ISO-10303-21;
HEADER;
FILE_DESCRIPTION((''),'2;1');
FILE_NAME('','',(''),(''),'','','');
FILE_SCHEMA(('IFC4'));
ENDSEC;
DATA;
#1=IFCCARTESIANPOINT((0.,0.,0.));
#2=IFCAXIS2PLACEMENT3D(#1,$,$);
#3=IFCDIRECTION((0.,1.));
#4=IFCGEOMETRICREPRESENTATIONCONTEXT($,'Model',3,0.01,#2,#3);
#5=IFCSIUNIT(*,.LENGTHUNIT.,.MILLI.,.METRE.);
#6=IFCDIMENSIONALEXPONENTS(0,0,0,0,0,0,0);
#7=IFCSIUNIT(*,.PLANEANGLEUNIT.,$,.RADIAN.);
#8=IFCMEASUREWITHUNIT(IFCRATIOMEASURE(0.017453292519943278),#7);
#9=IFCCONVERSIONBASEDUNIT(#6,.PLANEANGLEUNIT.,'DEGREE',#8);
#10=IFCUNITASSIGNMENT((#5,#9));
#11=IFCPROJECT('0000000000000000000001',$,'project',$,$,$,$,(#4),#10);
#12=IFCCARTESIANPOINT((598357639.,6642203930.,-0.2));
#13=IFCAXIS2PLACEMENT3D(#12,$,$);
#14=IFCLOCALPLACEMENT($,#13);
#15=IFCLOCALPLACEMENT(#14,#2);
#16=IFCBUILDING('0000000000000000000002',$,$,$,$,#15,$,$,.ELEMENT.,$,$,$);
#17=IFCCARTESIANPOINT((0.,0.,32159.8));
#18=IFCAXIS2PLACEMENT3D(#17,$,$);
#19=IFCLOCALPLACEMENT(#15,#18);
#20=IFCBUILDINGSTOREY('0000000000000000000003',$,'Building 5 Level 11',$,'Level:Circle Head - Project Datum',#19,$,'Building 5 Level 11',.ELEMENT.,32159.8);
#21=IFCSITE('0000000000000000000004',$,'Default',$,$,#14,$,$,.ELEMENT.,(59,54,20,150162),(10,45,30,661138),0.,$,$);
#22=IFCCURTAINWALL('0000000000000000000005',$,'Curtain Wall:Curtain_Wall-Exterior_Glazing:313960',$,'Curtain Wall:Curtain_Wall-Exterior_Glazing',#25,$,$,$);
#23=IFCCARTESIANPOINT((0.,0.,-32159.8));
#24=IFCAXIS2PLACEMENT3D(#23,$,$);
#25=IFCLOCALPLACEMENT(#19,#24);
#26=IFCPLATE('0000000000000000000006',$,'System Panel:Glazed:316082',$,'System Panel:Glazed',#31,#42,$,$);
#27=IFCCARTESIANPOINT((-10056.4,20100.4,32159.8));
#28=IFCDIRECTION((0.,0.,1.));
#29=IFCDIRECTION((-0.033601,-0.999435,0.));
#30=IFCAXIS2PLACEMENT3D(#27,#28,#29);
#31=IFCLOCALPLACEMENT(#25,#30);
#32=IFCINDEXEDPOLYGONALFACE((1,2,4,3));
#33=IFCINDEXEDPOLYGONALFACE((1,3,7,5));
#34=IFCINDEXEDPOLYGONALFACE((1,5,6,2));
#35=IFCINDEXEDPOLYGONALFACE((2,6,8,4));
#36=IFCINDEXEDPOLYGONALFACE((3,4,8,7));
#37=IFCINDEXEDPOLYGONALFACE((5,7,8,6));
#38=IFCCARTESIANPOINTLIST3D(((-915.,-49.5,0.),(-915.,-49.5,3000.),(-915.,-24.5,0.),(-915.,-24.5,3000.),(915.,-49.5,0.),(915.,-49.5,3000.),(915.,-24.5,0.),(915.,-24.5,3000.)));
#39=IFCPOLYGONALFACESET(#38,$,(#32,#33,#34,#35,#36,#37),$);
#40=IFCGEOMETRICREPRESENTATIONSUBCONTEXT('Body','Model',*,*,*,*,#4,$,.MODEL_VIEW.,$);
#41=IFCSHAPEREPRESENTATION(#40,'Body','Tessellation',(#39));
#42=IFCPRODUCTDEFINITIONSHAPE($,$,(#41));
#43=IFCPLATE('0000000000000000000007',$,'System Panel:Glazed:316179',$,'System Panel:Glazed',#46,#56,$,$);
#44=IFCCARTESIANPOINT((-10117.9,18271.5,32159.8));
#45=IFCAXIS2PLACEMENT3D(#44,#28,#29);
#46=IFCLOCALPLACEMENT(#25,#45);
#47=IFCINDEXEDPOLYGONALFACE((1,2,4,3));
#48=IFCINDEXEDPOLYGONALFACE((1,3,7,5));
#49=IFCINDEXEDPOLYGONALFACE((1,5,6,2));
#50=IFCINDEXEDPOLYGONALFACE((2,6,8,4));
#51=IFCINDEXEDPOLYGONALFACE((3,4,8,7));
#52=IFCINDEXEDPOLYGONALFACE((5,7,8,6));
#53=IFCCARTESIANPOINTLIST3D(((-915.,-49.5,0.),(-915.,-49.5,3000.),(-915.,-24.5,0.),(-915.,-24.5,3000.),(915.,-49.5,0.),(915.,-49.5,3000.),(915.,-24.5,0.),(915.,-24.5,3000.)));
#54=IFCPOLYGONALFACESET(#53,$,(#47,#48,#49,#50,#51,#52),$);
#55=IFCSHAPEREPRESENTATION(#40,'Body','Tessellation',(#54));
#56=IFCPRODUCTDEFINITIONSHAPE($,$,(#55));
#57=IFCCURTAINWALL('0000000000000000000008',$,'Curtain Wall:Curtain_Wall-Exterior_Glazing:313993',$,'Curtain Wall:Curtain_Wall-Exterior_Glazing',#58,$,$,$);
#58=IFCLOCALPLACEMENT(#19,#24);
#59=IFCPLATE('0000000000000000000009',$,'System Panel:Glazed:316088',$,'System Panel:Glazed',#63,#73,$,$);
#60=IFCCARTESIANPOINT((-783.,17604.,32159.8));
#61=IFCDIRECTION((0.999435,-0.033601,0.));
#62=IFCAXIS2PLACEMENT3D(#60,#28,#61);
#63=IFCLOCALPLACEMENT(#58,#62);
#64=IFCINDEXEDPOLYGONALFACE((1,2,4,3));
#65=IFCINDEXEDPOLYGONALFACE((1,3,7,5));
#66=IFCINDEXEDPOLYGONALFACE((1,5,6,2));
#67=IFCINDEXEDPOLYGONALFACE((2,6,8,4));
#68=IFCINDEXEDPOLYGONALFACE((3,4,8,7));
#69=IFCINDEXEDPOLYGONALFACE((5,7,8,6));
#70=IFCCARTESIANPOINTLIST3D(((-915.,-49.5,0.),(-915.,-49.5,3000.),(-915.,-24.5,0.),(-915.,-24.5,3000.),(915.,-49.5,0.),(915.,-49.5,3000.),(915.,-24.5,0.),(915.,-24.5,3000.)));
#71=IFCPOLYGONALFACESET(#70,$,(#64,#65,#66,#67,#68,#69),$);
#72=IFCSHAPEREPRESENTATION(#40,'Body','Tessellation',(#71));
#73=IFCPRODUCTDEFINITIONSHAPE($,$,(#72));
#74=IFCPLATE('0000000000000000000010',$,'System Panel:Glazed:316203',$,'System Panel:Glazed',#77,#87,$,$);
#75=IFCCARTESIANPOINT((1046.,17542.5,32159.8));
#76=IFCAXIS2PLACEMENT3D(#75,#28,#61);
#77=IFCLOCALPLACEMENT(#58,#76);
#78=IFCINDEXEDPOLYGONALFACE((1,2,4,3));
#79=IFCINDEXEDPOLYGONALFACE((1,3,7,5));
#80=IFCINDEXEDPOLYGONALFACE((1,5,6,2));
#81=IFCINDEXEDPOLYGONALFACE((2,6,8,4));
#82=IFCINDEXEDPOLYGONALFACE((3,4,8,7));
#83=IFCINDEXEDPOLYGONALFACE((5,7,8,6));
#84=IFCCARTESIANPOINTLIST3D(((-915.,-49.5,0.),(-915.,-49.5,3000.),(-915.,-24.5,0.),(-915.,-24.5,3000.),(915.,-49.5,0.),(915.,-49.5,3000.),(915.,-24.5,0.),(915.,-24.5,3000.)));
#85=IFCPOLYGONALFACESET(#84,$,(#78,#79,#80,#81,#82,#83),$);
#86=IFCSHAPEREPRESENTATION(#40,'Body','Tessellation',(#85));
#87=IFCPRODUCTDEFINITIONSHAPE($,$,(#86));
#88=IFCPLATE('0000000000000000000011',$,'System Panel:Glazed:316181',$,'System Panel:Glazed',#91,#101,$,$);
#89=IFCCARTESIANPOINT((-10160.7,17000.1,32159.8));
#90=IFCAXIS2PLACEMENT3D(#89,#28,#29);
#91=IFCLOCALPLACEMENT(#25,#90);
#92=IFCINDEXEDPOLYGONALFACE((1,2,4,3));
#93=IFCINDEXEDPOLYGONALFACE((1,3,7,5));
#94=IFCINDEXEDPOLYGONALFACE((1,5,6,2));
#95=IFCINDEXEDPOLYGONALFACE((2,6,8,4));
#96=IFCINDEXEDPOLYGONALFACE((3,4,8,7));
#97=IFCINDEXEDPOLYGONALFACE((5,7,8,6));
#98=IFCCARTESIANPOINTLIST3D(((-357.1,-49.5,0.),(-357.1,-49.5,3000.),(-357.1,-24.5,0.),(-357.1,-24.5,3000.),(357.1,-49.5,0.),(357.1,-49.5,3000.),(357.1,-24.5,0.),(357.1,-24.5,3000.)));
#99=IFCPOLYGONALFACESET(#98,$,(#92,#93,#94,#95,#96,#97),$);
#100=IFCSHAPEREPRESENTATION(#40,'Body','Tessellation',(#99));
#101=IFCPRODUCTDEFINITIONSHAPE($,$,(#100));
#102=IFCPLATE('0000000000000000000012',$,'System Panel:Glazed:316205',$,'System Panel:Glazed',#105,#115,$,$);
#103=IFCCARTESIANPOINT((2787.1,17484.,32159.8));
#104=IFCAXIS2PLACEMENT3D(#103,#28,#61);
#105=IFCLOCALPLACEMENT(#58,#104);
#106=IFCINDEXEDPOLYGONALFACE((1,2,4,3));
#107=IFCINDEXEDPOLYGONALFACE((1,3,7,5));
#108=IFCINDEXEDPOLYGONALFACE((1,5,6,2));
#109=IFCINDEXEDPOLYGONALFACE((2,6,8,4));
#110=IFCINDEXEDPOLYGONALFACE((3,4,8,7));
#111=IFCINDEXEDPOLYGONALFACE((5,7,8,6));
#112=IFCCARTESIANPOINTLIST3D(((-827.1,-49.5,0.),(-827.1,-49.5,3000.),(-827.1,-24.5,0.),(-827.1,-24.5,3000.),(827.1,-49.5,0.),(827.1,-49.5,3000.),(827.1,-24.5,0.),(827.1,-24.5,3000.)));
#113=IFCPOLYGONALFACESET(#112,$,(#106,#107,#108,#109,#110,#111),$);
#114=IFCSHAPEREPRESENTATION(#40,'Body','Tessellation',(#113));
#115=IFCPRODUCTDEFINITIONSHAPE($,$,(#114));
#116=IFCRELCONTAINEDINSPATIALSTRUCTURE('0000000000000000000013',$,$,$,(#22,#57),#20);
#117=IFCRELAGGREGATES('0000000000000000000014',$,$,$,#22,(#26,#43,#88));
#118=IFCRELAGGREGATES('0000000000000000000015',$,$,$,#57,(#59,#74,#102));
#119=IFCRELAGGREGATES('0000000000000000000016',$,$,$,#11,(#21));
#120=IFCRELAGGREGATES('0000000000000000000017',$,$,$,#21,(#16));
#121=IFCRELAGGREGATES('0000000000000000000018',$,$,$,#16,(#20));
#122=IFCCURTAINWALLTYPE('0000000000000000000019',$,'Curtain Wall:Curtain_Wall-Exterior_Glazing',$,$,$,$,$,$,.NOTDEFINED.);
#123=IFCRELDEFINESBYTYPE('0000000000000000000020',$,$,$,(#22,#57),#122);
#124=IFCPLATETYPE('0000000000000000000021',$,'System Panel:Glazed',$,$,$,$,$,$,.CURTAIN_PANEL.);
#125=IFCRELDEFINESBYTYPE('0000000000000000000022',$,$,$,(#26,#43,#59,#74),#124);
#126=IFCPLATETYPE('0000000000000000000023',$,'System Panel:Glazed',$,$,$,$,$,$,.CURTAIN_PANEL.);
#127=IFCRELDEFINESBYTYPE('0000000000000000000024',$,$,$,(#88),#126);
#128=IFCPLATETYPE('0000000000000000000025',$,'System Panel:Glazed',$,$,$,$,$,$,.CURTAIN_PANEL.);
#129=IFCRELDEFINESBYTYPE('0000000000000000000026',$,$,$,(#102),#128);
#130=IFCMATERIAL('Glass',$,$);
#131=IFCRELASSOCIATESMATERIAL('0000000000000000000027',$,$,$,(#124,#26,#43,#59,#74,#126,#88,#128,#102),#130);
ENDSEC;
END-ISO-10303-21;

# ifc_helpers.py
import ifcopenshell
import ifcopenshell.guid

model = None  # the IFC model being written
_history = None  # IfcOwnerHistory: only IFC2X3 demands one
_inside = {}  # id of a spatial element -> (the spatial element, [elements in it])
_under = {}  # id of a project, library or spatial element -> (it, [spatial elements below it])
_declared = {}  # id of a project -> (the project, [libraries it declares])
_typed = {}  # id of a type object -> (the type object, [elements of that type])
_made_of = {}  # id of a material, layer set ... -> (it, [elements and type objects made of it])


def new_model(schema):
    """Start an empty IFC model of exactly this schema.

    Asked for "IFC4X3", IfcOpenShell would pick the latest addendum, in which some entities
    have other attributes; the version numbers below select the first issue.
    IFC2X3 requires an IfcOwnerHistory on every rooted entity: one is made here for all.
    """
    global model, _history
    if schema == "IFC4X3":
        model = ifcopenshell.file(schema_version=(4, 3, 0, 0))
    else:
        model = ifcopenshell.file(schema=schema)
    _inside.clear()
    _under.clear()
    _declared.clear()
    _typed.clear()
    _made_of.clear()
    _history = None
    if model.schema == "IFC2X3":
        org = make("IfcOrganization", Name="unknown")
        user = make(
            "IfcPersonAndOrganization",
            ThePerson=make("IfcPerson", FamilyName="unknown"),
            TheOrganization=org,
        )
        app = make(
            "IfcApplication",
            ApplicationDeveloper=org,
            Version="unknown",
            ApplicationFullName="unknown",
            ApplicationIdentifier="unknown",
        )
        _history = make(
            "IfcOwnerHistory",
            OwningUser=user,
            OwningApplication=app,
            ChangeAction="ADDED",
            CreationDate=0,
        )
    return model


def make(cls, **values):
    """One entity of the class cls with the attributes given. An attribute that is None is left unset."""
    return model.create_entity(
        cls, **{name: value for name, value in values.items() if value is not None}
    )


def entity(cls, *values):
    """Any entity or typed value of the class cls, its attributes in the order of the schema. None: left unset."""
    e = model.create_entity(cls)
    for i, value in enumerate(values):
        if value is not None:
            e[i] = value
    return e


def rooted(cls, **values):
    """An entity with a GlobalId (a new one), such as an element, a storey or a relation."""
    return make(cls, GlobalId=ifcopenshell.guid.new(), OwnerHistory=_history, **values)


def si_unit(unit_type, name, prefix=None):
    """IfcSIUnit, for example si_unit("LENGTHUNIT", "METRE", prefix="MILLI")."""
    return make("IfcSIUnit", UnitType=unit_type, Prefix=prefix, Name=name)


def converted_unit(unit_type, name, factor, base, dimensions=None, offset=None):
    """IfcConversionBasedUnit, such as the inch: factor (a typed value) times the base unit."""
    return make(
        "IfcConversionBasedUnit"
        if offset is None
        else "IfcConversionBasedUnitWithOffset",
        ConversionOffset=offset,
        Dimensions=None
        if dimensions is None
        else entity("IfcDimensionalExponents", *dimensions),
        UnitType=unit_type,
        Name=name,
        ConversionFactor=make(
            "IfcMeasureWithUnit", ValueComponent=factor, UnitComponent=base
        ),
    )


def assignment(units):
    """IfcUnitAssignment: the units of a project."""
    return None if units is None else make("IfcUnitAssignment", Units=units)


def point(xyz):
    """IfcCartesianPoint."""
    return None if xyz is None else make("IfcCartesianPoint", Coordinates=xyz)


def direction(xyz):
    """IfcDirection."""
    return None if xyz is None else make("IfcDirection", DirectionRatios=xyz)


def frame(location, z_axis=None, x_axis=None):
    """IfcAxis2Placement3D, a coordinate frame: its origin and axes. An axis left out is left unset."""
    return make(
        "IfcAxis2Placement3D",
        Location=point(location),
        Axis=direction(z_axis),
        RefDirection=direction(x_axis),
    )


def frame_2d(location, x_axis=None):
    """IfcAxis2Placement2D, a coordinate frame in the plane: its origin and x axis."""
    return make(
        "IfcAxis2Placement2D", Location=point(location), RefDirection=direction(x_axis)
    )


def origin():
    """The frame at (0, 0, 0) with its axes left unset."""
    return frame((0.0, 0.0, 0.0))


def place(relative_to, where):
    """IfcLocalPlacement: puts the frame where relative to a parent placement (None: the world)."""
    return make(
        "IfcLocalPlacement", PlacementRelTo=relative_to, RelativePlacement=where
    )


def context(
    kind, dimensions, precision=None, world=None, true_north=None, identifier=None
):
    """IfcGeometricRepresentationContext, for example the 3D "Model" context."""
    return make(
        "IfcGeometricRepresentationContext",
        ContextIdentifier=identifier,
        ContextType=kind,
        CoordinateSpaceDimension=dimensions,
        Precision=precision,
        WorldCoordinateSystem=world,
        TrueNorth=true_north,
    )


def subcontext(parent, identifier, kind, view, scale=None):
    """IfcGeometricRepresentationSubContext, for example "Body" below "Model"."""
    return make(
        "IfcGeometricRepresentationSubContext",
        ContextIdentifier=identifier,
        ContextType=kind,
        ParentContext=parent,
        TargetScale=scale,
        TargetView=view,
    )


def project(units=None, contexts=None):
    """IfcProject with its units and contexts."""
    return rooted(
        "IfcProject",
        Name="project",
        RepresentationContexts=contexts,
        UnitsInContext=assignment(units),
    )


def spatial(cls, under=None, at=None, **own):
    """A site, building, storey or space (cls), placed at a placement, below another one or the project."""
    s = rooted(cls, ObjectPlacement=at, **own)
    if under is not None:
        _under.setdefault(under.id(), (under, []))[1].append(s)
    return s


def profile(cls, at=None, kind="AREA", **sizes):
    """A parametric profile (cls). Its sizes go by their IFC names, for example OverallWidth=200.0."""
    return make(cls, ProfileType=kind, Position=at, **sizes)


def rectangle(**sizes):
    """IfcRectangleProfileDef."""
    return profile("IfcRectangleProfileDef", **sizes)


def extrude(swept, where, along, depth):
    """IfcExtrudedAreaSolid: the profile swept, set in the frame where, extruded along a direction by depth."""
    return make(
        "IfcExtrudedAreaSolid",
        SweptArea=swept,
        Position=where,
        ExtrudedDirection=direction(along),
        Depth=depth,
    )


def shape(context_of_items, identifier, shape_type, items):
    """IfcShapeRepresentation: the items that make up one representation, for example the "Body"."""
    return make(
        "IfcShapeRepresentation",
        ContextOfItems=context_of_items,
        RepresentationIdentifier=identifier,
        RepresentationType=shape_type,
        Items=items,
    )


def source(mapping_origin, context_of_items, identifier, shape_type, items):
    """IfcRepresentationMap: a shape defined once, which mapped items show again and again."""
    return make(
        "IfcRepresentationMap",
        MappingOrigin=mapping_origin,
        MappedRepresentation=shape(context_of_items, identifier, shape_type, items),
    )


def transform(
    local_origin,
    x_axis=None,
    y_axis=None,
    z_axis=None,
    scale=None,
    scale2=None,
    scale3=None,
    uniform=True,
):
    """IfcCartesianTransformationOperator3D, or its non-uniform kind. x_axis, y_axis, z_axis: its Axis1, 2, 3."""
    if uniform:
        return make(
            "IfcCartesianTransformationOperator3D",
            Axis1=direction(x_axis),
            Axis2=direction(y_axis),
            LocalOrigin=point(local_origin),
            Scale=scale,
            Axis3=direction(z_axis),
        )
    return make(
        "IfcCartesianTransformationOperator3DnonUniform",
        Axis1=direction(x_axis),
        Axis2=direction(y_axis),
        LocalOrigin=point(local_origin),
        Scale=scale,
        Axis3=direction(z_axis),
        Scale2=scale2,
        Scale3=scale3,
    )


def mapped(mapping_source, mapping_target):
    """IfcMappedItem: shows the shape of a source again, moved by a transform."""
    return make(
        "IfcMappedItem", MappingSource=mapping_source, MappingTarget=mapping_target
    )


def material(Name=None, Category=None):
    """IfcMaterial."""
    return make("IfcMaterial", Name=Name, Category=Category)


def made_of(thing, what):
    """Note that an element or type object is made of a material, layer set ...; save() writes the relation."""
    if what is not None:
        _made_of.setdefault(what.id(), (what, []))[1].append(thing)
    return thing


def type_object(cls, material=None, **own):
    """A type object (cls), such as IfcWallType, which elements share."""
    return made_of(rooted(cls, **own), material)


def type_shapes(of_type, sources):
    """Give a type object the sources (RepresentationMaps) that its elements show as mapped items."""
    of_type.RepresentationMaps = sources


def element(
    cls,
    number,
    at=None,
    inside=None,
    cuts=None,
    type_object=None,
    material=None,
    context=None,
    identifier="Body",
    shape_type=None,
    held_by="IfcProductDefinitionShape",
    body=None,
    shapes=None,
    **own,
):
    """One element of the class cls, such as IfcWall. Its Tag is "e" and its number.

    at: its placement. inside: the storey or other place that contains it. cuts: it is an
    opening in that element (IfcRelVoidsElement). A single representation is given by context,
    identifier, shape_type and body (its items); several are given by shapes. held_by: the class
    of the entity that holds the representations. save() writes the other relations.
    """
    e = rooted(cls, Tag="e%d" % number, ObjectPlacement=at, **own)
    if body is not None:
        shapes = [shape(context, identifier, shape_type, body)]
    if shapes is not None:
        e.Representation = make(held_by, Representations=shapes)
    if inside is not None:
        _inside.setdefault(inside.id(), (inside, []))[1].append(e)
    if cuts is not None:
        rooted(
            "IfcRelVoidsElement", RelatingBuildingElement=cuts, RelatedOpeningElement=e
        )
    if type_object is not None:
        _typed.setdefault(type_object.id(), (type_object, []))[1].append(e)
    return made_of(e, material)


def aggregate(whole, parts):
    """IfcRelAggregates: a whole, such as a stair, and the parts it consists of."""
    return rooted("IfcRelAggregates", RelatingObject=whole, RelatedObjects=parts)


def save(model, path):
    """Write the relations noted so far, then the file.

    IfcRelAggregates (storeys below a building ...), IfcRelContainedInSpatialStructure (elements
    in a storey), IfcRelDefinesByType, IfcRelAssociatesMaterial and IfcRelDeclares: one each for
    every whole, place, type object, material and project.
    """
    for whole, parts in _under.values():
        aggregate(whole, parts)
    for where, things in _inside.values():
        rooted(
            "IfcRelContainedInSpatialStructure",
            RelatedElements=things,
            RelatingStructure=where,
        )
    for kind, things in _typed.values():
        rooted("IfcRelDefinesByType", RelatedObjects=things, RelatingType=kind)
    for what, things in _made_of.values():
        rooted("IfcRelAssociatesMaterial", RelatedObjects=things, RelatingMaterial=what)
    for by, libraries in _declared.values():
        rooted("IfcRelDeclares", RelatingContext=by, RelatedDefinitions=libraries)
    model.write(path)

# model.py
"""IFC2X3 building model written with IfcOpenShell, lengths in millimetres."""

from ifc_helpers import new_model, entity, si_unit, converted_unit, direction, frame, frame_2d, origin, place, context, subcontext, project, spatial, rectangle, extrude, source, transform, mapped, material, type_object, type_shapes, element, aggregate, save


model = new_model("IFC2X3")

# Units and contexts
model_context = context("Model", 3, precision=0.01, world=origin(), true_north=direction((0.0, 1.0)))
body_context = subcontext(model_context, "Body", "Model", "MODEL_VIEW")
ifc_project = project(units=[si_unit("LENGTHUNIT", "METRE", prefix="MILLI"), converted_unit("PLANEANGLEUNIT", "DEGREE", entity("IfcRatioMeasure", 0.017453292519943278), si_unit("PLANEANGLEUNIT", "RADIAN"), dimensions=[0, 0, 0, 0, 0, 0, 0])], contexts=[model_context])

# Site, building, storey
site_placement = place(None, frame((598357639.0, 6642203930.0, -0.2)))
site = spatial("IfcSite", under=ifc_project, at=site_placement, Name="Default", CompositionType="ELEMENT", RefLatitude=(59, 54, 20, 150162), RefLongitude=(10, 45, 30, 661138), RefElevation=0.0)
building_placement = place(site_placement, origin())
building = spatial("IfcBuilding", under=site, at=building_placement, CompositionType="ELEMENT")
storey_placement = place(building_placement, frame((0.0, 0.0, 32159.8)))
storey = spatial("IfcBuildingStorey", under=building, at=storey_placement, Name="Building 5 Level 11", ObjectType="Level:Circle Head - Project Datum", LongName="Building 5 Level 11", CompositionType="ELEMENT", Elevation=32159.8)

# Curtain walls, plates
curtain_wall_type = type_object("IfcCurtainWallType", Name="Curtain Wall:Curtain_Wall-Exterior_Glazing", PredefinedType="NOTDEFINED")
curtain_wall_1_placement = place(storey_placement, frame((0.0, 0.0, -32159.8)))
curtain_wall_1 = element("IfcCurtainWall", 1, at=curtain_wall_1_placement, inside=storey, type_object=curtain_wall_type, Name="Curtain Wall:Curtain_Wall-Exterior_Glazing:313960", ObjectType="Curtain Wall:Curtain_Wall-Exterior_Glazing")
ifc_material_1 = material(Name="Glass")
plate_type_1 = type_object("IfcPlateType", Name="System Panel:Glazed", PredefinedType="CURTAIN_PANEL", material=ifc_material_1)
shared_shape_1 = source(origin(), body_context, "Body", "SweptSolid", [
    extrude(rectangle(XDim=25.0, YDim=1830.0, at=frame_2d((0.0, 0.0), x_axis=(1.0, 0.0))), frame((0.0, -37.0, 0.0), z_axis=(0.0, 0.0, 1.0), x_axis=(0.0, 1.0, 0.0)), (0.0, 0.0, 1.0), 3000.0),
])
type_shapes(plate_type_1, [shared_shape_1])
plate_1_placement = place(curtain_wall_1_placement, frame((-10056.4, 20100.4, 32159.8), z_axis=(0.0, 0.0, 1.0), x_axis=(-0.033601, -0.999435, 0.0)))
plate_1 = element("IfcPlate", 2, at=plate_1_placement, type_object=plate_type_1, material=ifc_material_1, Name="System Panel:Glazed:316082", ObjectType="System Panel:Glazed", context=body_context, shape_type="MappedRepresentation", body=[
    mapped(shared_shape_1, transform((0.0, 0.0, 0.0), scale=1.0)),
])
plate_2_placement = place(curtain_wall_1_placement, frame((-10117.9, 18271.5, 32159.8), z_axis=(0.0, 0.0, 1.0), x_axis=(-0.033601, -0.999435, 0.0)))
plate_2 = element("IfcPlate", 3, at=plate_2_placement, type_object=plate_type_1, material=ifc_material_1, Name="System Panel:Glazed:316179", ObjectType="System Panel:Glazed", context=body_context, shape_type="MappedRepresentation", body=[
    mapped(shared_shape_1, transform((0.0, 0.0, 0.0), scale=1.0)),
])
curtain_wall_2_placement = place(storey_placement, frame((0.0, 0.0, -32159.8)))
curtain_wall_2 = element("IfcCurtainWall", 4, at=curtain_wall_2_placement, inside=storey, type_object=curtain_wall_type, Name="Curtain Wall:Curtain_Wall-Exterior_Glazing:313993", ObjectType="Curtain Wall:Curtain_Wall-Exterior_Glazing")
plate_3_placement = place(curtain_wall_2_placement, frame((-783.0, 17604.0, 32159.8), z_axis=(0.0, 0.0, 1.0), x_axis=(0.999435, -0.033601, 0.0)))
plate_3 = element("IfcPlate", 5, at=plate_3_placement, type_object=plate_type_1, material=ifc_material_1, Name="System Panel:Glazed:316088", ObjectType="System Panel:Glazed", context=body_context, shape_type="MappedRepresentation", body=[
    mapped(shared_shape_1, transform((0.0, 0.0, 0.0), scale=1.0)),
])
plate_4_placement = place(curtain_wall_2_placement, frame((1046.0, 17542.5, 32159.8), z_axis=(0.0, 0.0, 1.0), x_axis=(0.999435, -0.033601, 0.0)))
plate_4 = element("IfcPlate", 6, at=plate_4_placement, type_object=plate_type_1, material=ifc_material_1, Name="System Panel:Glazed:316203", ObjectType="System Panel:Glazed", context=body_context, shape_type="MappedRepresentation", body=[
    mapped(shared_shape_1, transform((0.0, 0.0, 0.0), scale=1.0)),
])

# Plates
plate_type_2 = type_object("IfcPlateType", Name="System Panel:Glazed", PredefinedType="CURTAIN_PANEL", material=ifc_material_1)
shared_shape_2 = source(origin(), body_context, "Body", "SweptSolid", [
    extrude(rectangle(XDim=25.0, YDim=714.2, at=frame_2d((0.0, 0.0), x_axis=(1.0, 0.0))), frame((0.0, -37.0, 0.0), z_axis=(0.0, 0.0, 1.0), x_axis=(0.0, 1.0, 0.0)), (0.0, 0.0, 1.0), 3000.0),
])
type_shapes(plate_type_2, [shared_shape_2])
plate_5_placement = place(curtain_wall_1_placement, frame((-10160.7, 17000.1, 32159.8), z_axis=(0.0, 0.0, 1.0), x_axis=(-0.033601, -0.999435, 0.0)))
plate_5 = element("IfcPlate", 7, at=plate_5_placement, type_object=plate_type_2, material=ifc_material_1, Name="System Panel:Glazed:316181", ObjectType="System Panel:Glazed", context=body_context, shape_type="MappedRepresentation", body=[
    mapped(shared_shape_2, transform((0.0, 0.0, 0.0), scale=1.0)),
])
aggregate(curtain_wall_1, [plate_1, plate_2, plate_5])
plate_type_3 = type_object("IfcPlateType", Name="System Panel:Glazed", PredefinedType="CURTAIN_PANEL", material=ifc_material_1)
shared_shape_3 = source(origin(), body_context, "Body", "SweptSolid", [
    extrude(rectangle(XDim=25.0, YDim=1654.3, at=frame_2d((0.0, 0.0), x_axis=(1.0, 0.0))), frame((0.0, -37.0, 0.0), z_axis=(0.0, 0.0, 1.0), x_axis=(0.0, 1.0, 0.0)), (0.0, 0.0, 1.0), 3000.0),
])
type_shapes(plate_type_3, [shared_shape_3])
plate_6_placement = place(curtain_wall_2_placement, frame((2787.1, 17484.0, 32159.8), z_axis=(0.0, 0.0, 1.0), x_axis=(0.999435, -0.033601, 0.0)))
plate_6 = element("IfcPlate", 8, at=plate_6_placement, type_object=plate_type_3, material=ifc_material_1, Name="System Panel:Glazed:316205", ObjectType="System Panel:Glazed", context=body_context, shape_type="MappedRepresentation", body=[
    mapped(shared_shape_3, transform((0.0, 0.0, 0.0), scale=1.0)),
])
aggregate(curtain_wall_2, [plate_3, plate_4, plate_6])

save(model, "model.ifc")
